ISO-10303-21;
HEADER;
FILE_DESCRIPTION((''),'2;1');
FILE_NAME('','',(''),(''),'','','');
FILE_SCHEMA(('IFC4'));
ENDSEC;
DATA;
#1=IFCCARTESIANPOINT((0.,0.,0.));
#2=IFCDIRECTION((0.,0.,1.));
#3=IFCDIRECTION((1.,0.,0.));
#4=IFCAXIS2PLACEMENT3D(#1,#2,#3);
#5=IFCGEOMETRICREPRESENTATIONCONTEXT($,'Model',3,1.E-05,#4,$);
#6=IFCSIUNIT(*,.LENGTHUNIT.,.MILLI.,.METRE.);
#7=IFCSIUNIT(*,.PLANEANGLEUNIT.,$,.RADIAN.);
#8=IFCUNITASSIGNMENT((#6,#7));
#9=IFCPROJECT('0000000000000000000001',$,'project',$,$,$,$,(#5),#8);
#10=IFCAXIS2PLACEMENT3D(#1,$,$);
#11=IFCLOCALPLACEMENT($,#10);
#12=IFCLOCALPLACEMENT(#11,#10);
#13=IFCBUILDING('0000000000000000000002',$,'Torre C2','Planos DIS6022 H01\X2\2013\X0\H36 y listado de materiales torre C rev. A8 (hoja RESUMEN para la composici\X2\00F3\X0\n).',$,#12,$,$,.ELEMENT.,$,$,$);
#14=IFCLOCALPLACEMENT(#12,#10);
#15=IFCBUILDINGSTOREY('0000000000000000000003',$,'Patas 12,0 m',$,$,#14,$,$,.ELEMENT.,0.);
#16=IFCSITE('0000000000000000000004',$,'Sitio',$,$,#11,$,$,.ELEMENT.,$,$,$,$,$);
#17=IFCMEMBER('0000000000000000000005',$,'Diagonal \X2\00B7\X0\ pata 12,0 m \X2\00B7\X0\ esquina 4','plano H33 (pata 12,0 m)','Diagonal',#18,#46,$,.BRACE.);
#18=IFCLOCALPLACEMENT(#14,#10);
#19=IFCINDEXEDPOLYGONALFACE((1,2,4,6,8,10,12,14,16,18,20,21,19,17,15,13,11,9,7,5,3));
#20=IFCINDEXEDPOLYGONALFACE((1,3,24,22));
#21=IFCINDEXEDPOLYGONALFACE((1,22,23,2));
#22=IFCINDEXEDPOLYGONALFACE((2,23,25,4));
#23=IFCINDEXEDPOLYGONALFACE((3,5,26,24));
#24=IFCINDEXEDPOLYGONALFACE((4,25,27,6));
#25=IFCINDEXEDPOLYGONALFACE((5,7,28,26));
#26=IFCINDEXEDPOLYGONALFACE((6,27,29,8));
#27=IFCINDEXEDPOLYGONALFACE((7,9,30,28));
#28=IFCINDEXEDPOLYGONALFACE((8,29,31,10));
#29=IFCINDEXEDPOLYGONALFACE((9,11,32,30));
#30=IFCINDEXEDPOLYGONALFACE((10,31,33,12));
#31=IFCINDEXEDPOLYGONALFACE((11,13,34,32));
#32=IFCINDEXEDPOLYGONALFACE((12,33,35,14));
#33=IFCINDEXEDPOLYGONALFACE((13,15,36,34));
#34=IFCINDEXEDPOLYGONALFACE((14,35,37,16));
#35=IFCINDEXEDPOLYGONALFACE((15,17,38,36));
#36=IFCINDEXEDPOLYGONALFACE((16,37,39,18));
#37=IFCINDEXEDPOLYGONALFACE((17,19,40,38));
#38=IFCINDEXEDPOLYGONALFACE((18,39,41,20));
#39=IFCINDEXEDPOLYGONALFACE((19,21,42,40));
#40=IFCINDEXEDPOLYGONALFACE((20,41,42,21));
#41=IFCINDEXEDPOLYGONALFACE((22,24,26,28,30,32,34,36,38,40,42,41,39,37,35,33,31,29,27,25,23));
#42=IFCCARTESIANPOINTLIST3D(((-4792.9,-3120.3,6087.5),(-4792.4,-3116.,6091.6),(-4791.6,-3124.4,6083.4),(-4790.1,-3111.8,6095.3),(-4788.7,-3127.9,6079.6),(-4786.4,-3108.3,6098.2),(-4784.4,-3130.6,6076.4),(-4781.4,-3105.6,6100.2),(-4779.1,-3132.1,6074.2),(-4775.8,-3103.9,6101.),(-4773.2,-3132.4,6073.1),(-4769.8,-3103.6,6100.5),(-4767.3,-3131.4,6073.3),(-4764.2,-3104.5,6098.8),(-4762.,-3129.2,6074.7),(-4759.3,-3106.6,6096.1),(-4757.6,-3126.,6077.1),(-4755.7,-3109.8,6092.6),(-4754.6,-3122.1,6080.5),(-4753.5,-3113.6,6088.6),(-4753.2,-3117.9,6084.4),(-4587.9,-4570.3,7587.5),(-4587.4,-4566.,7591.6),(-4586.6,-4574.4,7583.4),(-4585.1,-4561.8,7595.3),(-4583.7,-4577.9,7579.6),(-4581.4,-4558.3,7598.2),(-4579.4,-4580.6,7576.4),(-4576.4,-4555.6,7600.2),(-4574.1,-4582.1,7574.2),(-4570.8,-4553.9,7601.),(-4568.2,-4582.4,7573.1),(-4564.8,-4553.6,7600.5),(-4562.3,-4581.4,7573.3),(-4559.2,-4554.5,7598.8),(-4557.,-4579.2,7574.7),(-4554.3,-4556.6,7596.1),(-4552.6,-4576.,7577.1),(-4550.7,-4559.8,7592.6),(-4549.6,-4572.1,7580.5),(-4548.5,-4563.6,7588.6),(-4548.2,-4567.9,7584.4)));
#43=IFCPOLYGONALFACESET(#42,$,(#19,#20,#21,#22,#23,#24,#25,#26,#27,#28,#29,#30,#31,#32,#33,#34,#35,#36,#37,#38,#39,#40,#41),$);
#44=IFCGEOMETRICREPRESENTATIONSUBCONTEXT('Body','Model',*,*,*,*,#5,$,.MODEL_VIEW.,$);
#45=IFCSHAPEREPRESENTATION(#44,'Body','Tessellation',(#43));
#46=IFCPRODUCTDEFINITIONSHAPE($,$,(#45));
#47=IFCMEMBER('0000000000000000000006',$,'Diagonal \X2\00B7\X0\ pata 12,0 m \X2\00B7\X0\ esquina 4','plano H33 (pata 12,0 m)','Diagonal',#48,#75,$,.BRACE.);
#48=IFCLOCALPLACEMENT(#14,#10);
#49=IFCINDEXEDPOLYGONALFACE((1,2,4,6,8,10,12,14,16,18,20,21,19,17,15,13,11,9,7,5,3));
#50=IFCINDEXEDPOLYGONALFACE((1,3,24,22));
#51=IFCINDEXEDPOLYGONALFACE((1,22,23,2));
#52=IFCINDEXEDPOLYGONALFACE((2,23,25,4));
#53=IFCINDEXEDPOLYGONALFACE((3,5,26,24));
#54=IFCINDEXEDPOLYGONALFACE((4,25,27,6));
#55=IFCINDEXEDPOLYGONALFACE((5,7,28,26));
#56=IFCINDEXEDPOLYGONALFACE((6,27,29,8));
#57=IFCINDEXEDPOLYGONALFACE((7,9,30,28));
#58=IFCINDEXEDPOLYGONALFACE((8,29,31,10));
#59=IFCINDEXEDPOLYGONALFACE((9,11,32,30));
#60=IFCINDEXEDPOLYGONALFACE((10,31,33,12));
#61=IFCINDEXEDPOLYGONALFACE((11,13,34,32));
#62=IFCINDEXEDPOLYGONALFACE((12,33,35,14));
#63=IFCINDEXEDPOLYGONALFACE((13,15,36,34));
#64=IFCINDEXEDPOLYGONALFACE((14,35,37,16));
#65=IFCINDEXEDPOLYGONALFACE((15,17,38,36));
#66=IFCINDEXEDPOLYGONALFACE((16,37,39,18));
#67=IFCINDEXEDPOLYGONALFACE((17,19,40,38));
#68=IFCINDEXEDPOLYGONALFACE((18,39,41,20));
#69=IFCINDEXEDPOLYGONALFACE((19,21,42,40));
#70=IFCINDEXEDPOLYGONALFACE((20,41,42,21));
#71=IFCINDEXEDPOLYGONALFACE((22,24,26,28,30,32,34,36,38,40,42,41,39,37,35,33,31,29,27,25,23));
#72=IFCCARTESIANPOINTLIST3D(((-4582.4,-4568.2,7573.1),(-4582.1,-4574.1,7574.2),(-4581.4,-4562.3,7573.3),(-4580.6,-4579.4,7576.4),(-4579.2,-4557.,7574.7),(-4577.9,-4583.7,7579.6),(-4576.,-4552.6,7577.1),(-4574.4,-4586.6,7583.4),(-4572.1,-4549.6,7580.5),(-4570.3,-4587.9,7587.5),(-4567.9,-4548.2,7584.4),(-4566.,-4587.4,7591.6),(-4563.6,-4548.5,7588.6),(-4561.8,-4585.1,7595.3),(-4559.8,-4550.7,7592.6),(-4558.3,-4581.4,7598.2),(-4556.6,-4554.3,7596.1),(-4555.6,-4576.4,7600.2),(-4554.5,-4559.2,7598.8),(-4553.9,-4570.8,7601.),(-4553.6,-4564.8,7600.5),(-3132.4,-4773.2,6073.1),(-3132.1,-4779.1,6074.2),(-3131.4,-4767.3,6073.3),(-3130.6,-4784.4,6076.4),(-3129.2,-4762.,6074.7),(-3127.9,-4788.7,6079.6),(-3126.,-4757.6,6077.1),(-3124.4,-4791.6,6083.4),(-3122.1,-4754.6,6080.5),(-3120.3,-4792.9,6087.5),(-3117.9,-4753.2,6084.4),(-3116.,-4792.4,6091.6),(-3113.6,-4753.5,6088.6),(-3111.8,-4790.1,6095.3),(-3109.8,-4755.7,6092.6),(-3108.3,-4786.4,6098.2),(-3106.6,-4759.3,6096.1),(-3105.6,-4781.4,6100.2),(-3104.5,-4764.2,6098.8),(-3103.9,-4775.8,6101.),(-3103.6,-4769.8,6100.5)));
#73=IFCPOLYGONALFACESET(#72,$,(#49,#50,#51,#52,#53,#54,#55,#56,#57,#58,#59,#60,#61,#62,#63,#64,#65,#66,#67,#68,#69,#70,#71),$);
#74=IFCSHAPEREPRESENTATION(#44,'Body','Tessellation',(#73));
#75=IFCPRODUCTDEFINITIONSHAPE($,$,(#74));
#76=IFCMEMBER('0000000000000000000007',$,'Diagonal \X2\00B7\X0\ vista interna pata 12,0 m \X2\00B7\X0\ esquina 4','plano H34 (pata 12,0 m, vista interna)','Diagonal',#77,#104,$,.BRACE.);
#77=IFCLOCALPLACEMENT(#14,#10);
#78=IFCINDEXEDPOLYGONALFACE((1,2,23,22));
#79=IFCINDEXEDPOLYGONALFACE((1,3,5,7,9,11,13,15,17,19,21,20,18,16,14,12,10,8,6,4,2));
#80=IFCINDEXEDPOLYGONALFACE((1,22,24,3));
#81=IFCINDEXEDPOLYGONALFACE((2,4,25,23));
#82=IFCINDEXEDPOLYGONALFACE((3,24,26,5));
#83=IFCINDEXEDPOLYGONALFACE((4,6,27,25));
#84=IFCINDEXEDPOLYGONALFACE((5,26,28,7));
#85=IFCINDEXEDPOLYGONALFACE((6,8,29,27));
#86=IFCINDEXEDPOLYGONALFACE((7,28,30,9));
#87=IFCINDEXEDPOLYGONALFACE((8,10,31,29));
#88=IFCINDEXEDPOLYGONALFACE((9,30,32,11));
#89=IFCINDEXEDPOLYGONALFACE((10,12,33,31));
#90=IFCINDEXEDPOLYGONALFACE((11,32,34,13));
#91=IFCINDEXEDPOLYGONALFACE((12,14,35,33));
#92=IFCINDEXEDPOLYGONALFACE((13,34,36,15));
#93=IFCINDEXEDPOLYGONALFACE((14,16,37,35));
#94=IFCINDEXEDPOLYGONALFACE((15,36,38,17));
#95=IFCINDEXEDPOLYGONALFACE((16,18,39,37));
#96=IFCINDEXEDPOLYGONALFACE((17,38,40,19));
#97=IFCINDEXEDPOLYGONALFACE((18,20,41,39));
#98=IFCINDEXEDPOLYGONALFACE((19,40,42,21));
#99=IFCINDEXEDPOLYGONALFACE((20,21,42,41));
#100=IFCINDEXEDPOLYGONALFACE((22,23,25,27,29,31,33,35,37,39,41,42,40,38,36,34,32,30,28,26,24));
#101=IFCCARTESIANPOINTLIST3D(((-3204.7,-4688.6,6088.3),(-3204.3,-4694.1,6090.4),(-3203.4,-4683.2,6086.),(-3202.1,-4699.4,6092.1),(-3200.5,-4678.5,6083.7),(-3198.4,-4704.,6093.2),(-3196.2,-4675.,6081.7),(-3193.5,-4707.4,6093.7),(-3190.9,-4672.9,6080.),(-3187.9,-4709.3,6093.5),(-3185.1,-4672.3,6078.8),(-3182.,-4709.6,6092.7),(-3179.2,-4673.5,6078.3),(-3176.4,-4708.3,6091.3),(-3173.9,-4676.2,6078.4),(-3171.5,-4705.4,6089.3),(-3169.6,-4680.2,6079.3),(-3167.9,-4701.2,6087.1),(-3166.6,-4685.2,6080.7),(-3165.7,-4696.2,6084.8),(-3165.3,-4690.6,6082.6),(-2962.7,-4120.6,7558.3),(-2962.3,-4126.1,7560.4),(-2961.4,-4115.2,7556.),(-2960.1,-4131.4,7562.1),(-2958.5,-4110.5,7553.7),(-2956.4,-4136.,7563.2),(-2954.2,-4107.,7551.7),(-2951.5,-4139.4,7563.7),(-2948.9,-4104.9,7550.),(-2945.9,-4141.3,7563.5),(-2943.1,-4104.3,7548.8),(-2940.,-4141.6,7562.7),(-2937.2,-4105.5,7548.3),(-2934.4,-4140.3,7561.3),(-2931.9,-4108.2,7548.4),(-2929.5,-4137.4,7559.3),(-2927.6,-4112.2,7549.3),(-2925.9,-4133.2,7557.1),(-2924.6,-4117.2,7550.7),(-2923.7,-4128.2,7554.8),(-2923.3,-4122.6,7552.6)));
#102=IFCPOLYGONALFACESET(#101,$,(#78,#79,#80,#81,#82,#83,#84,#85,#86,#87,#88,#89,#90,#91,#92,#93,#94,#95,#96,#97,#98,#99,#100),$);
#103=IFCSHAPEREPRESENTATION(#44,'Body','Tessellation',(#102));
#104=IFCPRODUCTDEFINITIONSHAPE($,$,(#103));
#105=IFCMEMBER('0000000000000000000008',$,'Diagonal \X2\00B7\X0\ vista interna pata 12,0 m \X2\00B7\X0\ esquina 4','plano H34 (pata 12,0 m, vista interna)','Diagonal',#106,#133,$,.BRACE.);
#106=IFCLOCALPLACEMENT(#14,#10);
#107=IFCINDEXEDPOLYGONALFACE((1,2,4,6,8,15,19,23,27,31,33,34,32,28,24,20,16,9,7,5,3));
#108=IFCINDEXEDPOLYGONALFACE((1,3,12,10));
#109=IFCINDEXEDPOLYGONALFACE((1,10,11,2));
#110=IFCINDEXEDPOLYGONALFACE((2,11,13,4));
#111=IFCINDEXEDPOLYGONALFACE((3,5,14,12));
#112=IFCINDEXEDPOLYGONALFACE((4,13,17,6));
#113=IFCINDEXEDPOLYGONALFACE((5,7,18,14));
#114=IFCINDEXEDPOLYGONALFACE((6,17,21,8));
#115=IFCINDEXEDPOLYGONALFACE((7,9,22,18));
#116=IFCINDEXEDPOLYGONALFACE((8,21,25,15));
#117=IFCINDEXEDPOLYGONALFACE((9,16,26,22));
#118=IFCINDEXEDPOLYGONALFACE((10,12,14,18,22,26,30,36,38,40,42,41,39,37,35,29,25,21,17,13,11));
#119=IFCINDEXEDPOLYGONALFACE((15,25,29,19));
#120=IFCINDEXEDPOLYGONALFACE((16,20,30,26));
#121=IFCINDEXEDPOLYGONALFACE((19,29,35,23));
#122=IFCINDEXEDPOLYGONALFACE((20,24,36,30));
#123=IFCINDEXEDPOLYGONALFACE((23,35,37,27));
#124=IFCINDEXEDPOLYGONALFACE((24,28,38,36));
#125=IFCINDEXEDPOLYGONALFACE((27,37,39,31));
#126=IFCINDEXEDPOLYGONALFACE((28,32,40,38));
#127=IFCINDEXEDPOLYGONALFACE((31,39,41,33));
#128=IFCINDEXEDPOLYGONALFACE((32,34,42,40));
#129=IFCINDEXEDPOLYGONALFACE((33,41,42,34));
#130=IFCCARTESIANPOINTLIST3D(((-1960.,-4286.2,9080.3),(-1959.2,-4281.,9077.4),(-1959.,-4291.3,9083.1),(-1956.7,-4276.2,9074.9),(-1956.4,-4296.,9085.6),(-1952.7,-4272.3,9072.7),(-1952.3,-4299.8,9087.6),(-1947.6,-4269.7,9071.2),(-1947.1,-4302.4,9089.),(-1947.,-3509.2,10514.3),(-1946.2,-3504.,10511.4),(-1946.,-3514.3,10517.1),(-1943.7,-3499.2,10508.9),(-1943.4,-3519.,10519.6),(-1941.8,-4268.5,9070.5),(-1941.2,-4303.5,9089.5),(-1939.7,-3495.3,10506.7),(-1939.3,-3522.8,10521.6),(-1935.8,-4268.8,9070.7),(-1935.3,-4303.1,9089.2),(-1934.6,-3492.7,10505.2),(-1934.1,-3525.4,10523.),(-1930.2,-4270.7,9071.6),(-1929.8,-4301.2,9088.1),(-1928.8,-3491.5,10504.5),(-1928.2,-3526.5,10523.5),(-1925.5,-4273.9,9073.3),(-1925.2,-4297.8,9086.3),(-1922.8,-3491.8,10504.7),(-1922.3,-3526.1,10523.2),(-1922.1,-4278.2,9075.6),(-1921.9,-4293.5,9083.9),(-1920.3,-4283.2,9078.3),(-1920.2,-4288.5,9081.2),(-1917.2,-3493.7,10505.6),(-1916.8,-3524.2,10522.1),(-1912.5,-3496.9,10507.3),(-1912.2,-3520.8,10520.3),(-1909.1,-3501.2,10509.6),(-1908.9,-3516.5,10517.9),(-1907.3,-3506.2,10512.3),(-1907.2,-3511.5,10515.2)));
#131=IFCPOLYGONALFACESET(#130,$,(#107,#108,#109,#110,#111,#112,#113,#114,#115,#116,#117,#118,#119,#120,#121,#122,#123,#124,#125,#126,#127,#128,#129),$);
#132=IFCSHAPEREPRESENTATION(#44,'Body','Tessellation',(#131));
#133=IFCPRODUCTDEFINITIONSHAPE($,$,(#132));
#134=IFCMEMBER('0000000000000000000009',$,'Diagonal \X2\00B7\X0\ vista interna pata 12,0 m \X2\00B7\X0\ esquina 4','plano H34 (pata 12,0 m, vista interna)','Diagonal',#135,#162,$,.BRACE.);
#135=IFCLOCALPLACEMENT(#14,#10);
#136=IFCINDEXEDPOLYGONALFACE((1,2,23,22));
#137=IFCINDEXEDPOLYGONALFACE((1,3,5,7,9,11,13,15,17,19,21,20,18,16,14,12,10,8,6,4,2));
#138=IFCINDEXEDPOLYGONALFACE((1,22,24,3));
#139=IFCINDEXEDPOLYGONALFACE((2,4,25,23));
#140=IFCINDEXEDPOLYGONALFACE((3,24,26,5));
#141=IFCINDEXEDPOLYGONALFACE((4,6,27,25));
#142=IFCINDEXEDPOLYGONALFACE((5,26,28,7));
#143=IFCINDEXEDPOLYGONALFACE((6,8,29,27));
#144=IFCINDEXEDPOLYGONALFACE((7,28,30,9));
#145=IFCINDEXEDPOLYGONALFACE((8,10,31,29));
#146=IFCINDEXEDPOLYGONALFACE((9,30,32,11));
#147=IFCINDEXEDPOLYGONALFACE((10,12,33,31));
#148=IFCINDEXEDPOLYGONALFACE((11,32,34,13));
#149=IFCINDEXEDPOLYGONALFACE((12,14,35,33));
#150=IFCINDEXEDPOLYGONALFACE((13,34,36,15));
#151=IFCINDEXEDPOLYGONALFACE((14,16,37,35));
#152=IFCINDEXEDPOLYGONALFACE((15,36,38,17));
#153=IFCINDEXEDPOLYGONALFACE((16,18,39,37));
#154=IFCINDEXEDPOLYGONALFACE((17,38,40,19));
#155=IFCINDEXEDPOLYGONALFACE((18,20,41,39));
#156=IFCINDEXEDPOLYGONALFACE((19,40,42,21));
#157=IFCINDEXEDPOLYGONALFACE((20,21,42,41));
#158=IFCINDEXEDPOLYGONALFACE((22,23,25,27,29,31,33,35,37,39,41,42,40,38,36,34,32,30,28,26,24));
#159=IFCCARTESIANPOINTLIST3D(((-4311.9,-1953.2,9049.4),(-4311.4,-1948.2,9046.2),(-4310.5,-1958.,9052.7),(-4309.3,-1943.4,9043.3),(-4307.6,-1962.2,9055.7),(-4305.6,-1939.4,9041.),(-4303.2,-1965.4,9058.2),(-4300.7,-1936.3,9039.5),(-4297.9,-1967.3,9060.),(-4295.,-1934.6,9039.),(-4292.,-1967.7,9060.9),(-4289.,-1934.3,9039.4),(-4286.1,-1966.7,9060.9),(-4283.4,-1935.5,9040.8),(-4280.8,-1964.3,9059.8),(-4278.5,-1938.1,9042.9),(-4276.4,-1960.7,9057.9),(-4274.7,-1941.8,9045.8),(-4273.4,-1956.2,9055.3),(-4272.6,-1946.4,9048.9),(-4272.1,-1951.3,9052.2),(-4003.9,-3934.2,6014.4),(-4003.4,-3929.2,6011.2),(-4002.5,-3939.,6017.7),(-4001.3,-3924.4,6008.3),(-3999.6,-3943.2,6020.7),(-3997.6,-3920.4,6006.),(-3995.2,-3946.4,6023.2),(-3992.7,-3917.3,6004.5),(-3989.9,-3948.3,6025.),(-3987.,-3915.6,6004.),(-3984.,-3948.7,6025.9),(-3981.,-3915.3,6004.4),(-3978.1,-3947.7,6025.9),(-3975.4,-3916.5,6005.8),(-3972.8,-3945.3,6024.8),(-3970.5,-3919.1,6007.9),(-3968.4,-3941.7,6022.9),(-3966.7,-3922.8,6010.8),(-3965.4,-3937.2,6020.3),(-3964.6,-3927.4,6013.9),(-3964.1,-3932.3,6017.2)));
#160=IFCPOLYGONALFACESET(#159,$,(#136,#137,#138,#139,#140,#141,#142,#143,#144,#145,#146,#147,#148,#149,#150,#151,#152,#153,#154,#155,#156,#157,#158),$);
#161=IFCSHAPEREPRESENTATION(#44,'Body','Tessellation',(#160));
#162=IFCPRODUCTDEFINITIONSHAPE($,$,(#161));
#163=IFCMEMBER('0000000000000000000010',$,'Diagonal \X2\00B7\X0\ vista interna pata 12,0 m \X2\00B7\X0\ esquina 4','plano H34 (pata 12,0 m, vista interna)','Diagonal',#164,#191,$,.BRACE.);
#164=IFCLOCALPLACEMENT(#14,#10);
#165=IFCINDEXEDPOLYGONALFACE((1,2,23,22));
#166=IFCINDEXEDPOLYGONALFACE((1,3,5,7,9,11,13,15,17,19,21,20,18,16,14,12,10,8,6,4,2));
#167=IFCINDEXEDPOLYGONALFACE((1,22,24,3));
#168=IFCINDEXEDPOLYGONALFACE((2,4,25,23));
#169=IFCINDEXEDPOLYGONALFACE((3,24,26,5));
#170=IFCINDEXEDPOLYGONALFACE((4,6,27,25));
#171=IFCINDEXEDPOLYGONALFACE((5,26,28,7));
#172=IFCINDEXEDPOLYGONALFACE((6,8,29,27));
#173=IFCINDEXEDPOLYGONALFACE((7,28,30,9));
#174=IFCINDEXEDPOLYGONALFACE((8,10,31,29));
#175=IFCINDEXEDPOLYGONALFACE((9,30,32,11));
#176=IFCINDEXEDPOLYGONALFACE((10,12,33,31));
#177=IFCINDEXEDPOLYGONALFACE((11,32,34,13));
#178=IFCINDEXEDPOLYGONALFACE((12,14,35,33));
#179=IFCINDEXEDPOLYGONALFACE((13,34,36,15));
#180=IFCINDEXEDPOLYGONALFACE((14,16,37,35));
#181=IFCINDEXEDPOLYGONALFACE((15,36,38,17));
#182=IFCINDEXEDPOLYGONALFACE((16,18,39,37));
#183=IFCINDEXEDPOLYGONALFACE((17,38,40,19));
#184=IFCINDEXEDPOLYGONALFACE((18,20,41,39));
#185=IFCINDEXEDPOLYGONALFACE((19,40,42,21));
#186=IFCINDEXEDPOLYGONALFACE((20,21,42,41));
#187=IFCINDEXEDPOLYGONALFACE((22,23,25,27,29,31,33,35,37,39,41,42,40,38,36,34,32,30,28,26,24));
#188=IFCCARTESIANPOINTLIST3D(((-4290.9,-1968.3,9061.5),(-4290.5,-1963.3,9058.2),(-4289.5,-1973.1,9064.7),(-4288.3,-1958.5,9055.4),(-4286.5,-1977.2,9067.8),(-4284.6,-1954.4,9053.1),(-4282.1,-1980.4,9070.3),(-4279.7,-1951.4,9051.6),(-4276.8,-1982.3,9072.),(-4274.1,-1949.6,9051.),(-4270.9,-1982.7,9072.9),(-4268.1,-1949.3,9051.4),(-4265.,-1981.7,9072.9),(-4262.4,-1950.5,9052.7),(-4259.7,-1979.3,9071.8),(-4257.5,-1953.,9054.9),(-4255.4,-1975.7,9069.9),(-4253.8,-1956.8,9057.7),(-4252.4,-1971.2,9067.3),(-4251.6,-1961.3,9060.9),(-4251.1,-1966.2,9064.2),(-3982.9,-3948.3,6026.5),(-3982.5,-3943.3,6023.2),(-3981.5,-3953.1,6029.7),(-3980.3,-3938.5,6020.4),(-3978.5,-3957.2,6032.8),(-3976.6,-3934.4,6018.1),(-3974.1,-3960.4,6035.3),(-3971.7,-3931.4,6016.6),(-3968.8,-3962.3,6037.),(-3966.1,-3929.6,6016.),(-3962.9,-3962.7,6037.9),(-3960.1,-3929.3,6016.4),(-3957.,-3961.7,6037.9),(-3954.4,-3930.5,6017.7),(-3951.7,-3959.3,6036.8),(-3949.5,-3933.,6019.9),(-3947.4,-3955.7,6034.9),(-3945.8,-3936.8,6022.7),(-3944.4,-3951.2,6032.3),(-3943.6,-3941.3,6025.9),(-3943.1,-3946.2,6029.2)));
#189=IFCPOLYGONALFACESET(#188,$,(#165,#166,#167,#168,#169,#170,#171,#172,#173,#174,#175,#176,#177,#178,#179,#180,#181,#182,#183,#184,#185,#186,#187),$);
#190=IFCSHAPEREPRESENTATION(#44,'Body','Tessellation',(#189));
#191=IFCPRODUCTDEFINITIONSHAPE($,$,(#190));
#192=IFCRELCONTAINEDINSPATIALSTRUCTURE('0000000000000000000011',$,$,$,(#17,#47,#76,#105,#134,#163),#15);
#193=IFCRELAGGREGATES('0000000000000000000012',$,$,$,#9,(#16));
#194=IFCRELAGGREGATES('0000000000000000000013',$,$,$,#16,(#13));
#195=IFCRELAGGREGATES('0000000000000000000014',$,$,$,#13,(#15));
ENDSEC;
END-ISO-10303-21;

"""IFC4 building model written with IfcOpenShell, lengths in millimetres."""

from ifc_helpers import new_model, si_unit, frame, origin, origin_with_axes, place, context, subcontext, project, spatial, circle, extrude, element, save


model = new_model("IFC4")

# Units and contexts
model_context = context("Model", 3, precision=1e-05, world=origin_with_axes())
body_context = subcontext(model_context, "Body", "Model", "MODEL_VIEW")
ifc_project = project(units=[si_unit("LENGTHUNIT", "METRE", prefix="MILLI"), si_unit("PLANEANGLEUNIT", "RADIAN")], contexts=[model_context])

# Site, building, storey
site_placement = place(None, origin())
site = spatial("IfcSite", under=ifc_project, at=site_placement, Name="Sitio", CompositionType="ELEMENT")
building_placement = place(site_placement, origin())
building = spatial("IfcBuilding", under=site, at=building_placement, Name="Torre C2", Description="Planos DIS6022 H01–H36 y listado de materiales torre C rev. A8 (hoja RESUMEN para la composición).", CompositionType="ELEMENT")
storey_placement = place(building_placement, origin())
storey = spatial("IfcBuildingStorey", under=building, at=storey_placement, Name="Patas 12,0 m", CompositionType="ELEMENT", Elevation=0.0)

# Members
for number, where, z_axis, x_axis, name in (
    (1, (-4568.0, -4568.0, 7587.0), (-0.097791, 0.691691, -0.715542), (0.867278, 0.411876, 0.279619), "Diagonal · pata 12,0 m · esquina 4"),
    (2, (-4568.0, -4568.0, 7587.0), (0.691691, -0.097791, -0.715542), (0.411876, 0.867278, 0.279619), "Diagonal · pata 12,0 m · esquina 4"),
):
    element("IfcMember", number, at=place(storey_placement, frame(where, z_axis=z_axis, x_axis=x_axis)), inside=storey, Name=name, Description="plano H33 (pata 12,0 m)", ObjectType="Diagonal", PredefinedType="BRACE", context=body_context, shape_type="SweptSolid", body=[
        extrude(circle(Radius=20.0), None, (0.0, 0.0, 1.0), 2096.3),
    ])
member_1_placement = place(storey_placement, frame((-2943.0, -4123.0, 7556.0), z_axis=(-0.151782, -0.356249, -0.921981), x_axis=(0.554715, 0.741338, -0.377769)))
element("IfcMember", 3, at=member_1_placement, inside=storey, Name="Diagonal · vista interna pata 12,0 m · esquina 4", Description="plano H34 (pata 12,0 m, vista interna)", ObjectType="Diagonal", PredefinedType="BRACE", context=body_context, shape_type="SweptSolid", body=[
    extrude(circle(Radius=20.0), None, (0.0, 0.0, 1.0), 1594.4),
])
member_2_placement = place(storey_placement, frame((-1927.0, -3509.0, 10514.0), z_axis=(-0.00797, -0.476387, -0.8792), x_axis=(0.488517, 0.765311, -0.419106)))
element("IfcMember", 4, at=member_2_placement, inside=storey, Name="Diagonal · vista interna pata 12,0 m · esquina 4", Description="plano H34 (pata 12,0 m, vista interna)", ObjectType="Diagonal", PredefinedType="BRACE", context=body_context, shape_type="SweptSolid", body=[
    extrude(circle(Radius=20.0), None, (0.0, 0.0, 1.0), 1631.0),
])
member_3_placement = place(storey_placement, frame((-4292.0, -1951.0, 9050.0), z_axis=(0.084677, -0.544624, -0.834394), x_axis=(0.862553, 0.459293, -0.212254)))
element("IfcMember", 5, at=member_3_placement, inside=storey, Name="Diagonal · vista interna pata 12,0 m · esquina 4", Description="plano H34 (pata 12,0 m, vista interna)", ObjectType="Diagonal", PredefinedType="BRACE", context=body_context, shape_type="SweptSolid", body=[
    extrude(circle(Radius=20.0), None, (0.0, 0.0, 1.0), 3637.4),
])
member_4_placement = place(storey_placement, frame((-4271.0, -1966.0, 9062.0), z_axis=(0.084689, -0.544431, -0.834519), x_axis=(0.860412, 0.462344, -0.214311)))
element("IfcMember", 6, at=member_4_placement, inside=storey, Name="Diagonal · vista interna pata 12,0 m · esquina 4", Description="plano H34 (pata 12,0 m, vista interna)", ObjectType="Diagonal", PredefinedType="BRACE", context=body_context, shape_type="SweptSolid", body=[
    extrude(circle(Radius=20.0), None, (0.0, 0.0, 1.0), 3636.8),
])

save(model, "model.ifc")
